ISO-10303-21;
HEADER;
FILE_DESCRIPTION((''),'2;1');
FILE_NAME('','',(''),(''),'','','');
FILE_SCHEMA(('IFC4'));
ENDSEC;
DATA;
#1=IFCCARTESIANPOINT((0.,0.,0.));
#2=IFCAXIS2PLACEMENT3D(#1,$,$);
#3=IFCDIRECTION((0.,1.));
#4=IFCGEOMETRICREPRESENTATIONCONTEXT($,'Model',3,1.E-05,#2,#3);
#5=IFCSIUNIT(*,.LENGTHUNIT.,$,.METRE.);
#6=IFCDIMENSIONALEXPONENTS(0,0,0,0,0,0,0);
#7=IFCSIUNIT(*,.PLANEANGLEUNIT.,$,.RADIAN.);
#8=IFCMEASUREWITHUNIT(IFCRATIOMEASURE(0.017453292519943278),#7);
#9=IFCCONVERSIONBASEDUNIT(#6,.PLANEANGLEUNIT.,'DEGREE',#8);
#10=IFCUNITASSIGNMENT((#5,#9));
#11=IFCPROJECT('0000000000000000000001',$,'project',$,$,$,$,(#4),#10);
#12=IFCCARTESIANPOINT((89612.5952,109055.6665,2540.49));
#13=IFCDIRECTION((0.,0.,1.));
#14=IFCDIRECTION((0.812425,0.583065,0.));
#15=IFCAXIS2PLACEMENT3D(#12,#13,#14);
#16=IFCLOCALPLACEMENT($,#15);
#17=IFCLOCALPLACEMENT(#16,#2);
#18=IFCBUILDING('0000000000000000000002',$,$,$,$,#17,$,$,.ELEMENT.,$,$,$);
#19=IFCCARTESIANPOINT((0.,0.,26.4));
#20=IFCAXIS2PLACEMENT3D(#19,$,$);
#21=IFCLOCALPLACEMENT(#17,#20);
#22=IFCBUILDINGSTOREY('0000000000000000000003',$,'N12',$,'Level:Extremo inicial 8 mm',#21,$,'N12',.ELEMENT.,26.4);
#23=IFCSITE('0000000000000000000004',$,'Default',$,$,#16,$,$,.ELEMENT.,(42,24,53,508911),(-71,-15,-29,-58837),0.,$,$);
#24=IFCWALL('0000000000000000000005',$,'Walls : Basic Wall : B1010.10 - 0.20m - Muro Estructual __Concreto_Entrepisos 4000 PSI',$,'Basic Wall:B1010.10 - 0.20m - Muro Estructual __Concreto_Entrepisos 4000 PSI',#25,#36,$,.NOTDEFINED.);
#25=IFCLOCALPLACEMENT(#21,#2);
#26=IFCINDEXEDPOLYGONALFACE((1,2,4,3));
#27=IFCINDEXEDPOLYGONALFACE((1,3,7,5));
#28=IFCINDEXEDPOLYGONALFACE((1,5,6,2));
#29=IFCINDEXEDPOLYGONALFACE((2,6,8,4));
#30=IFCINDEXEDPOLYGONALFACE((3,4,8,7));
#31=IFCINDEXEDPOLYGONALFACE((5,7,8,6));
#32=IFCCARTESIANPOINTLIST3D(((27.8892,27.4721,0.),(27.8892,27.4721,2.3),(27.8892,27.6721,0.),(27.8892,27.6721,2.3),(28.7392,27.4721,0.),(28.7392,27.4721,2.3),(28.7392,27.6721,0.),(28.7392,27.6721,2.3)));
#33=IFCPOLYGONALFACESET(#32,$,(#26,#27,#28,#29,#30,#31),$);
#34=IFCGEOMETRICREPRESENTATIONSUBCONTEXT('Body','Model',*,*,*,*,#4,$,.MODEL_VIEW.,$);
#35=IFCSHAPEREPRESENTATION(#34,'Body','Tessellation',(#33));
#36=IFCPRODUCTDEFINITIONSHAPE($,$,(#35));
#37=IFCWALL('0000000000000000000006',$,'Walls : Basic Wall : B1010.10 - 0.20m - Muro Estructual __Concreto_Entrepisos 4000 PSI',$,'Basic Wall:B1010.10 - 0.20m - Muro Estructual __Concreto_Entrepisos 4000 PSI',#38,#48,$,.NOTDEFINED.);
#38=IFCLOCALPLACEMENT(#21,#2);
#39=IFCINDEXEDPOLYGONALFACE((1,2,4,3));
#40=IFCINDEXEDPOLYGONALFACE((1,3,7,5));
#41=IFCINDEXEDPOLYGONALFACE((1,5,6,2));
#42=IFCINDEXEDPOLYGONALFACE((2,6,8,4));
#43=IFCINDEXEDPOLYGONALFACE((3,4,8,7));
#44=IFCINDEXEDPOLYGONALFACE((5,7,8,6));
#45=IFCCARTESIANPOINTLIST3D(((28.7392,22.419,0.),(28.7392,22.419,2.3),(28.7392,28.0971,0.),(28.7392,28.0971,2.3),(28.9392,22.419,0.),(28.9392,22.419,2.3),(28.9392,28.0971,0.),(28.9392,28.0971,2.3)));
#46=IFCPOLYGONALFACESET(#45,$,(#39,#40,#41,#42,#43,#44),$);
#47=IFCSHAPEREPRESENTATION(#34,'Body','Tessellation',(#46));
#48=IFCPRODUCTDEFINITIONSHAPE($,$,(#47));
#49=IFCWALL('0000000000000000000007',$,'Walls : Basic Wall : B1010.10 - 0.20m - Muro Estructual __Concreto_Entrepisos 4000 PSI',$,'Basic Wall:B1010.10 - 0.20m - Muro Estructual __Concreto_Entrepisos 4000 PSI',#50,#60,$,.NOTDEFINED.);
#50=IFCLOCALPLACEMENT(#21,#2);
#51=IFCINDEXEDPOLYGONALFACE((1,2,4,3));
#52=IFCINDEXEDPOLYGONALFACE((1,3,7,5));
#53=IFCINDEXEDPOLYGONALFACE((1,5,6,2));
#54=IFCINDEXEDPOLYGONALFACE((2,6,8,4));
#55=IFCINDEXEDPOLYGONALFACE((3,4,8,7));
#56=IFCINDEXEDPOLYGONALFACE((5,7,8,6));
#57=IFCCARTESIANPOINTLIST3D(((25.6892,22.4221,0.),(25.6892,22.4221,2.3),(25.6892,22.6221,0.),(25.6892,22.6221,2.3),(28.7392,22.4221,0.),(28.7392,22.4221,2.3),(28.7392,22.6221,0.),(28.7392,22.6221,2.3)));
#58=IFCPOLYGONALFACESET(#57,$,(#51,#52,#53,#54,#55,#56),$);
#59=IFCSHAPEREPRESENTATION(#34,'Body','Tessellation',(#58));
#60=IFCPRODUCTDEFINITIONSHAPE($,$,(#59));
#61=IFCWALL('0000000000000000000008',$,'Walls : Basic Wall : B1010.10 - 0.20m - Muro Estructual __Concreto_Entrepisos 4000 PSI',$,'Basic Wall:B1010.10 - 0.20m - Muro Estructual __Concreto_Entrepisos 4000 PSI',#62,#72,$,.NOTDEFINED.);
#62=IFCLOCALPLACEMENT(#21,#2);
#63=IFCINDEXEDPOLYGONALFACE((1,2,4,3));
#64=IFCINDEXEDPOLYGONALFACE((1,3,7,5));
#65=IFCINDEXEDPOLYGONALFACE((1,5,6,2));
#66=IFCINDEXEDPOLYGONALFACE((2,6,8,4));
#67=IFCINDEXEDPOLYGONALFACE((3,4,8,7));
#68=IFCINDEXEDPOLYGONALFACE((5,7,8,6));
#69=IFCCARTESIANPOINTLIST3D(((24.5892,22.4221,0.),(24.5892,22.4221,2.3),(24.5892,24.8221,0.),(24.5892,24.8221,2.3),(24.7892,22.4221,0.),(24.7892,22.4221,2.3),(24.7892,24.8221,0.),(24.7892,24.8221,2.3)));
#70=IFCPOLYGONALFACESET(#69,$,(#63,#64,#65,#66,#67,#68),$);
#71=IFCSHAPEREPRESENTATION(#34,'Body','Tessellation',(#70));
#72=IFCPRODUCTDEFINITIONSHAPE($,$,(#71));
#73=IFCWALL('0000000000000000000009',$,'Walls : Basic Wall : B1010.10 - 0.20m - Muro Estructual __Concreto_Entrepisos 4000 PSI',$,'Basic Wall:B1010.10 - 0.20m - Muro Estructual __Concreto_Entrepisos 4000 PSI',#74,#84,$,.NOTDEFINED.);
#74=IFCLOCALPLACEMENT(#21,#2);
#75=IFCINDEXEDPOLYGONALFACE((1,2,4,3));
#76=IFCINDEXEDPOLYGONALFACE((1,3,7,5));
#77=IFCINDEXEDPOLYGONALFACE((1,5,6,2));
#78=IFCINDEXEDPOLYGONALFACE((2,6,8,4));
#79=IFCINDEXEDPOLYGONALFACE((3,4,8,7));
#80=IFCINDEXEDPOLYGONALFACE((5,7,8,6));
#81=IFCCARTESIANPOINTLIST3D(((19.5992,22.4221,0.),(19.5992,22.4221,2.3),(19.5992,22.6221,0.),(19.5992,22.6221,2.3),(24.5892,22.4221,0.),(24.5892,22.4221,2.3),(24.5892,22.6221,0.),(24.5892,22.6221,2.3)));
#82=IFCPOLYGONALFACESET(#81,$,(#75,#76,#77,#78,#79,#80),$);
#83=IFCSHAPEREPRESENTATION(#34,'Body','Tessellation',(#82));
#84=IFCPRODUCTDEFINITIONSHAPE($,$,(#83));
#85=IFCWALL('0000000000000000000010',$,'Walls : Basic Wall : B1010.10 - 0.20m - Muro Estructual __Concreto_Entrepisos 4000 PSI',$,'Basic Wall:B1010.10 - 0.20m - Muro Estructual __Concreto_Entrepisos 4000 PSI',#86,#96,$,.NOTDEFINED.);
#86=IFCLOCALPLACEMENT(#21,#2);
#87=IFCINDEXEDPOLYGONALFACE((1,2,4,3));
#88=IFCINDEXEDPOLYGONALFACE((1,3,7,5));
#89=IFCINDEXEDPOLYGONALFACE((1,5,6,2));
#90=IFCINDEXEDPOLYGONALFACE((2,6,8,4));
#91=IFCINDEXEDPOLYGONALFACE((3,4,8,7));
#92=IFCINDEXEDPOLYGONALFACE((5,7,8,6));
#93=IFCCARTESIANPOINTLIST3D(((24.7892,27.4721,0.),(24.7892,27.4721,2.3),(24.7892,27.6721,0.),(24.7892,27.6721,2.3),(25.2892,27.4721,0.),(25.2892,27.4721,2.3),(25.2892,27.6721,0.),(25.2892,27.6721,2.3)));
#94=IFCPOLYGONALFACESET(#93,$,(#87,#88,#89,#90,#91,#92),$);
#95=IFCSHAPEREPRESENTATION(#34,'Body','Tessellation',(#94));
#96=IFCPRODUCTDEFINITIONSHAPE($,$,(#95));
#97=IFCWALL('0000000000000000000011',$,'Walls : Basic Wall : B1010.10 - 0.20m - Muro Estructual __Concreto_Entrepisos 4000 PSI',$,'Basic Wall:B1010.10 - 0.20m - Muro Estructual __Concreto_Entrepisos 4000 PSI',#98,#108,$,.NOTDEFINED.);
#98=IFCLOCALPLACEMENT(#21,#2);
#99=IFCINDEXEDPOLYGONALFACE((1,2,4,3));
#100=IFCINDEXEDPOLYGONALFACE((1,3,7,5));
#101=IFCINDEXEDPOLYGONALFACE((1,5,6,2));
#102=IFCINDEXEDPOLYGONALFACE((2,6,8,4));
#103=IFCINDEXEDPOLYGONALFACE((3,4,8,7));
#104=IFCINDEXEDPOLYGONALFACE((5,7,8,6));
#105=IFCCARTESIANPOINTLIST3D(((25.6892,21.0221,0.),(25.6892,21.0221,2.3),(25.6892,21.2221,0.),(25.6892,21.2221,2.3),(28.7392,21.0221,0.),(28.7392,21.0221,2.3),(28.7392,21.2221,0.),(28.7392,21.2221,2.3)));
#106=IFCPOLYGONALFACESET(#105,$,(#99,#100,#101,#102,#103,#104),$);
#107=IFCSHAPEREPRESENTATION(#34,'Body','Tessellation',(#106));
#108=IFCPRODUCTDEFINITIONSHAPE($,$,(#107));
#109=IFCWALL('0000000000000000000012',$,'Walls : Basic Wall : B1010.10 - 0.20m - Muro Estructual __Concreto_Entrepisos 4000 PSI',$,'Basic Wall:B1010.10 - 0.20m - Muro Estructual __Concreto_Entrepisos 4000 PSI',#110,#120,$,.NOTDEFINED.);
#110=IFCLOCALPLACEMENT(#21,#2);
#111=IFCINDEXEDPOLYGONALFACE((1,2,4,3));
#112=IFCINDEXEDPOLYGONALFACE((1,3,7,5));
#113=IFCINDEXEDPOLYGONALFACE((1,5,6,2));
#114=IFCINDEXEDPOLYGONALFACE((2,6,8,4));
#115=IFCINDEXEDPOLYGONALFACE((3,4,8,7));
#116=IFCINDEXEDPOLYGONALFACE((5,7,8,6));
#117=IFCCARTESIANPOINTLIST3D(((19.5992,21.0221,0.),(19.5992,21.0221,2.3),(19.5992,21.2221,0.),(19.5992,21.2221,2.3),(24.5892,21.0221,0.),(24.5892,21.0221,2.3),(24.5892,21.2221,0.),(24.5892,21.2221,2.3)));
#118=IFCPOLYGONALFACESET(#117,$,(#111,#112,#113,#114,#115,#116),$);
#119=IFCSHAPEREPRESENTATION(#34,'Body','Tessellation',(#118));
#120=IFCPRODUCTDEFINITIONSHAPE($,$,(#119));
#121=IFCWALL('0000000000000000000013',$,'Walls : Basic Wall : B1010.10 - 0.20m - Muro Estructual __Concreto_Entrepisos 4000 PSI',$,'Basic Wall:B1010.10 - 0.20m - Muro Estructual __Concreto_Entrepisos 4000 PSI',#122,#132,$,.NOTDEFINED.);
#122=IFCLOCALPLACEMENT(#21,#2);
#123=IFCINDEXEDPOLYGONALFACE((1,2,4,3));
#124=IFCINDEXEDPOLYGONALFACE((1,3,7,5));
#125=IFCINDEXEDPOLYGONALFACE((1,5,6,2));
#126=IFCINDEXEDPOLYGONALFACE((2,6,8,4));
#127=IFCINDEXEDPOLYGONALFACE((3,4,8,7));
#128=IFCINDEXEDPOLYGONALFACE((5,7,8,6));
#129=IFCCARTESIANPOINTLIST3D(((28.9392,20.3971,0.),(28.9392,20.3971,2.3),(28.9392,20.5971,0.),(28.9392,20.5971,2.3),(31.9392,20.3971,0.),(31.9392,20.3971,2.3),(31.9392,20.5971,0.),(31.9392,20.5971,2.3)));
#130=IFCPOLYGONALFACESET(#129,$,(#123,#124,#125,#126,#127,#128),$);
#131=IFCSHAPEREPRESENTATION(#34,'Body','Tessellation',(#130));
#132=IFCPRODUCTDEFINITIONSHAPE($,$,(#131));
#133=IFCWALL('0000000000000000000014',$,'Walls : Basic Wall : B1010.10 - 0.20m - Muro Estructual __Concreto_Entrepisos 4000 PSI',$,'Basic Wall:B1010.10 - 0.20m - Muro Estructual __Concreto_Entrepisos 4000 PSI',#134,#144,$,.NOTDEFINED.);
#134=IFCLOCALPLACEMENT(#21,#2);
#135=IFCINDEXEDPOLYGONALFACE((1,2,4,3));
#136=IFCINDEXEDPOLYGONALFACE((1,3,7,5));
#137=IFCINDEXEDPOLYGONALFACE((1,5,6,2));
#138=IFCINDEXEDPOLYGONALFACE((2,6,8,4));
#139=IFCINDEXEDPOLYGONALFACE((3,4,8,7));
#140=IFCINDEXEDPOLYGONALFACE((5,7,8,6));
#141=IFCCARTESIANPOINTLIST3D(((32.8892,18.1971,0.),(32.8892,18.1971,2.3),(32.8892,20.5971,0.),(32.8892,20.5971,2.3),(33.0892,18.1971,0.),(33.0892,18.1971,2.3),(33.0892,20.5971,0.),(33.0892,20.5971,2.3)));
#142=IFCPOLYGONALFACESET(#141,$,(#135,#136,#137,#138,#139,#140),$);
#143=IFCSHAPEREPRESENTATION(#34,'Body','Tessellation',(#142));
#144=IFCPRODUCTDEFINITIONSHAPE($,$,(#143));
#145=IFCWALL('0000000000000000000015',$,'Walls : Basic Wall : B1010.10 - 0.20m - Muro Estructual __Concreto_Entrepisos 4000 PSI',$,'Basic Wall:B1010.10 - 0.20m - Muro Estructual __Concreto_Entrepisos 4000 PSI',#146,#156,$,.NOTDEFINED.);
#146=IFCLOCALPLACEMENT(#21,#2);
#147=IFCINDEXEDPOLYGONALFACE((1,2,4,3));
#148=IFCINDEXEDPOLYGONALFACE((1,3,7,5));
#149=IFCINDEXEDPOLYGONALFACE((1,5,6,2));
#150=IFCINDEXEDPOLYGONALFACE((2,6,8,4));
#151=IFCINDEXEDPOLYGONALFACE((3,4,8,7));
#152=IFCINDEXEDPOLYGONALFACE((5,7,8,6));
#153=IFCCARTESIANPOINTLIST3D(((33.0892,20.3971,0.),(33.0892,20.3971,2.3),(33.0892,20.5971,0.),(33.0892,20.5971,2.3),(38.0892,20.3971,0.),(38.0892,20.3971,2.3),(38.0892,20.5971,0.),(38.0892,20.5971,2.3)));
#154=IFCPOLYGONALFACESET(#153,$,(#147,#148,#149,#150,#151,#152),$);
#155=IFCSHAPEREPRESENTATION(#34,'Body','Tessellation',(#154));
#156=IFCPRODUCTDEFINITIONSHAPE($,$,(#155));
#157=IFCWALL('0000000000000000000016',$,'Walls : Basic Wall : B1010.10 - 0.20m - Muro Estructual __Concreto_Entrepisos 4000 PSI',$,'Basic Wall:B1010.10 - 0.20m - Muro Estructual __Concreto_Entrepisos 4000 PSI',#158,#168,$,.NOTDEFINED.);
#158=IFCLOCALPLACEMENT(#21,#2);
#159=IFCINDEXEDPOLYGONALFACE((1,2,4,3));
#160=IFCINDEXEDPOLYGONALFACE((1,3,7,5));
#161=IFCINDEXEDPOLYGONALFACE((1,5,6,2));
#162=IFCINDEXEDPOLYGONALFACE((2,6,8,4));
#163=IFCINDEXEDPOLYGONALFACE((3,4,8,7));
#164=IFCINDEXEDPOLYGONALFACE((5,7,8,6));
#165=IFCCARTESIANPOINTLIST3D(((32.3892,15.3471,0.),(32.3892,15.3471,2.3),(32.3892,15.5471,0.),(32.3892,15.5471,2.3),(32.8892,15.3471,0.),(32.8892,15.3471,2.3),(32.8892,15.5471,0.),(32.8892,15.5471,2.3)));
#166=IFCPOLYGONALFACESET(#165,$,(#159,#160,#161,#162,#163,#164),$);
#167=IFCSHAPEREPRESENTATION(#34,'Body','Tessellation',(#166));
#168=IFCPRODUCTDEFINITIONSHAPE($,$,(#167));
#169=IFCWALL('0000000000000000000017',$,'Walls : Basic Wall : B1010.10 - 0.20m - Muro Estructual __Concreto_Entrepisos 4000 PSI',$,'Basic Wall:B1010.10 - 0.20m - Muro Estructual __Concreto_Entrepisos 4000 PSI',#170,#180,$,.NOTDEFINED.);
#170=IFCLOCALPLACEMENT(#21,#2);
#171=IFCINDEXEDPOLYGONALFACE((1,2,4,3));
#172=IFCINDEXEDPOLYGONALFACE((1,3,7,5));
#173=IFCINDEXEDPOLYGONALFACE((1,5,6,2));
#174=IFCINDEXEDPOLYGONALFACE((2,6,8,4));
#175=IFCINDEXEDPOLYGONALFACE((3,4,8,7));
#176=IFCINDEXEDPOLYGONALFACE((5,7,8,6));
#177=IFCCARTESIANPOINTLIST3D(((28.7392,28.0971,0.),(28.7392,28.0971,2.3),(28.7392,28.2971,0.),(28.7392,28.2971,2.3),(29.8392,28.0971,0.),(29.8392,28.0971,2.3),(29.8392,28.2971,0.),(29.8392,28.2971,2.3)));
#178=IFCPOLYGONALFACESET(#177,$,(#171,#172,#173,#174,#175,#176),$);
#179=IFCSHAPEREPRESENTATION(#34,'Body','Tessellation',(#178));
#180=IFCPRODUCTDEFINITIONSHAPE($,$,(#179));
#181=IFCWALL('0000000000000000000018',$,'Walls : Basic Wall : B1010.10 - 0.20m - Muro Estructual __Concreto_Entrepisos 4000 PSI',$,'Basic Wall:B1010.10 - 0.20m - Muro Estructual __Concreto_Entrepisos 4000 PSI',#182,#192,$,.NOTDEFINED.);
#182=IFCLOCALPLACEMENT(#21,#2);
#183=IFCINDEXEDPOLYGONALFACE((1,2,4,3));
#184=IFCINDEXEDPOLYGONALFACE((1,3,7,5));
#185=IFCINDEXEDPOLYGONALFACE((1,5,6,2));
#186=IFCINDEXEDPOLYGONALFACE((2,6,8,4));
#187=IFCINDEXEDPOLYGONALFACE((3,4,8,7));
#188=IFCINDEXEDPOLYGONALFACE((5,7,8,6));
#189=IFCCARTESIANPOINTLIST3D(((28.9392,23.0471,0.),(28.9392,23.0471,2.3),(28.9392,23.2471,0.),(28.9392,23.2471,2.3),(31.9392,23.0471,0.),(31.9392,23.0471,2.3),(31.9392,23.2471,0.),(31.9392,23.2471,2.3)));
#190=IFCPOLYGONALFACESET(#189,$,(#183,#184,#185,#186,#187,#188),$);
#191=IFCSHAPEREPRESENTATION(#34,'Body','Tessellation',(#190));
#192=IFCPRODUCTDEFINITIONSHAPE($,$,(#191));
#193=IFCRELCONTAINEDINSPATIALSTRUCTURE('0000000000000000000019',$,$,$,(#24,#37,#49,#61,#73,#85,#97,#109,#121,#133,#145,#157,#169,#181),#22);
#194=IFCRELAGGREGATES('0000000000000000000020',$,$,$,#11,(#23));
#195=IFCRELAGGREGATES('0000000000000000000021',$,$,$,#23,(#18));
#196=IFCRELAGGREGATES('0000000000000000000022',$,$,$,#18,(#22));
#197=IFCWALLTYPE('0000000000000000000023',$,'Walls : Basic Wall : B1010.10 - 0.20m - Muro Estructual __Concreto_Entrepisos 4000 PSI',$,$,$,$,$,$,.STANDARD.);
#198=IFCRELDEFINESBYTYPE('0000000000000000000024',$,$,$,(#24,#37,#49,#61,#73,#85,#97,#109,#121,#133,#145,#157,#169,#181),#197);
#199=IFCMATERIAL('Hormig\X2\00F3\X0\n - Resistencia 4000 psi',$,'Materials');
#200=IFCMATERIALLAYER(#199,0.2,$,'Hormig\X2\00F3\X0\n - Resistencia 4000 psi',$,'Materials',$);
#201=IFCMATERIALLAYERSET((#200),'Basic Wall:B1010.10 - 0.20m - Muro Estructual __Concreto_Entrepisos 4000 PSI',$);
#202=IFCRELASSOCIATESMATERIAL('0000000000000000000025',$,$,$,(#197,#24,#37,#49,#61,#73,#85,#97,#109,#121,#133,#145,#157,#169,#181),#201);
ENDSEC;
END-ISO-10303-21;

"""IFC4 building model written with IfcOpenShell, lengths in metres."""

from ifc_helpers import new_model, entity, si_unit, converted_unit, direction, frame, frame_2d, origin, place, context, subcontext, project, spatial, rectangle, extrude, material, layer, layer_set, layer_usage, type_object, element, save


model = new_model("IFC4")

# Units and contexts
model_context = context("Model", 3, precision=1e-05, world=origin(), true_north=direction((0.0, 1.0)))
body_context = subcontext(model_context, "Body", "Model", "MODEL_VIEW")
ifc_project = project(units=[si_unit("LENGTHUNIT", "METRE"), converted_unit("PLANEANGLEUNIT", "DEGREE", entity("IfcRatioMeasure", 0.017453292519943278), si_unit("PLANEANGLEUNIT", "RADIAN"), dimensions=[0, 0, 0, 0, 0, 0, 0])], contexts=[model_context])

# Site, building, storey
site_placement = place(None, frame((89612.5952, 109055.6665, 2540.49), z_axis=(0.0, 0.0, 1.0), x_axis=(0.812425, 0.583065, 0.0)))
site = spatial("IfcSite", under=ifc_project, at=site_placement, Name="Default", CompositionType="ELEMENT", RefLatitude=(42, 24, 53, 508911), RefLongitude=(-71, -15, -29, -58837), RefElevation=0.0)
building_placement = place(site_placement, origin())
building = spatial("IfcBuilding", under=site, at=building_placement, CompositionType="ELEMENT")
storey_placement = place(building_placement, frame((0.0, 0.0, 26.4)))
storey = spatial("IfcBuildingStorey", under=building, at=storey_placement, Name="N12", ObjectType="Level:Extremo inicial 8 mm", LongName="N12", CompositionType="ELEMENT", Elevation=26.4)

# Walls
ifc_material = material(Name="Hormigón - Resistencia 4000 psi", Category="Materials")
ifc_layer_1 = layer(ifc_material, 0.2, Name="Hormigón - Resistencia 4000 psi", Category="Materials")
ifc_layer_set_1 = layer_set([ifc_layer_1], Name="Basic Wall:B1010.10 - 0.20m - Muro Estructual __Concreto_Entrepisos 4000 PSI")
ifc_layer_usage_1 = layer_usage(ifc_layer_set_1, "AXIS2", "NEGATIVE", 0.1)
wall_type_1 = type_object("IfcWallType", Name="Walls : Basic Wall : B1010.10 - 0.20m - Muro Estructual __Concreto_Entrepisos 4000 PSI", PredefinedType="STANDARD", material=ifc_layer_set_1)
wall_1_placement = place(storey_placement, frame((27.8892, 27.5721, 0.0)))
element("IfcWall", 1, at=wall_1_placement, inside=storey, type_object=wall_type_1, material=ifc_layer_usage_1, Name="Walls : Basic Wall : B1010.10 - 0.20m - Muro Estructual __Concreto_Entrepisos 4000 PSI", ObjectType="Basic Wall:B1010.10 - 0.20m - Muro Estructual __Concreto_Entrepisos 4000 PSI", PredefinedType="NOTDEFINED", context=body_context, shape_type="SweptSolid", body=[
    extrude(rectangle(XDim=0.85, YDim=0.2, at=frame_2d((0.425, 0.0), x_axis=(-1.0, 0.0))), origin(), (0.0, 0.0, 1.0), 2.3),
])
ifc_layer_usage_2 = layer_usage(ifc_layer_set_1, "AXIS2", "NEGATIVE", 0.1)
wall_2_placement = place(storey_placement, frame((28.8392, 28.0971, 0.0), z_axis=(0.0, 0.0, 1.0), x_axis=(0.0, -1.0, 0.0)))
element("IfcWall", 2, at=wall_2_placement, inside=storey, type_object=wall_type_1, material=ifc_layer_usage_2, Name="Walls : Basic Wall : B1010.10 - 0.20m - Muro Estructual __Concreto_Entrepisos 4000 PSI", ObjectType="Basic Wall:B1010.10 - 0.20m - Muro Estructual __Concreto_Entrepisos 4000 PSI", PredefinedType="NOTDEFINED", context=body_context, shape_type="SweptSolid", body=[
    extrude(rectangle(XDim=5.6781, YDim=0.2, at=frame_2d((2.839, 0.0), x_axis=(-1.0, 0.0))), origin(), (0.0, 0.0, 1.0), 2.3),
])
ifc_layer_usage_3 = layer_usage(ifc_layer_set_1, "AXIS2", "NEGATIVE", 0.1)
wall_3_placement = place(storey_placement, frame((28.7392, 22.5221, 0.0), z_axis=(0.0, 0.0, 1.0), x_axis=(-1.0, 0.0, 0.0)))
element("IfcWall", 3, at=wall_3_placement, inside=storey, type_object=wall_type_1, material=ifc_layer_usage_3, Name="Walls : Basic Wall : B1010.10 - 0.20m - Muro Estructual __Concreto_Entrepisos 4000 PSI", ObjectType="Basic Wall:B1010.10 - 0.20m - Muro Estructual __Concreto_Entrepisos 4000 PSI", PredefinedType="NOTDEFINED", context=body_context, shape_type="SweptSolid", body=[
    extrude(rectangle(XDim=3.05, YDim=0.2, at=frame_2d((1.525, 0.0), x_axis=(-1.0, 0.0))), origin(), (0.0, 0.0, 1.0), 2.3),
])
ifc_layer_usage_4 = layer_usage(ifc_layer_set_1, "AXIS2", "NEGATIVE", 0.1)
wall_4_placement = place(storey_placement, frame((24.6892, 24.8221, 0.0), z_axis=(0.0, 0.0, 1.0), x_axis=(0.0, -1.0, 0.0)))
element("IfcWall", 4, at=wall_4_placement, inside=storey, type_object=wall_type_1, material=ifc_layer_usage_4, Name="Walls : Basic Wall : B1010.10 - 0.20m - Muro Estructual __Concreto_Entrepisos 4000 PSI", ObjectType="Basic Wall:B1010.10 - 0.20m - Muro Estructual __Concreto_Entrepisos 4000 PSI", PredefinedType="NOTDEFINED", context=body_context, shape_type="SweptSolid", body=[
    extrude(rectangle(XDim=2.4, YDim=0.2, at=frame_2d((1.2, 0.0), x_axis=(-1.0, 0.0))), origin(), (0.0, 0.0, 1.0), 2.3),
])
ifc_layer_usage_5 = layer_usage(ifc_layer_set_1, "AXIS2", "NEGATIVE", 0.1)
wall_5_placement = place(storey_placement, frame((24.5892, 22.5221, 0.0), z_axis=(0.0, 0.0, 1.0), x_axis=(-1.0, 0.0, 0.0)))
element("IfcWall", 5, at=wall_5_placement, inside=storey, type_object=wall_type_1, material=ifc_layer_usage_5, Name="Walls : Basic Wall : B1010.10 - 0.20m - Muro Estructual __Concreto_Entrepisos 4000 PSI", ObjectType="Basic Wall:B1010.10 - 0.20m - Muro Estructual __Concreto_Entrepisos 4000 PSI", PredefinedType="NOTDEFINED", context=body_context, shape_type="SweptSolid", body=[
    extrude(rectangle(XDim=4.99, YDim=0.2, at=frame_2d((2.495, 0.0), x_axis=(-1.0, 0.0))), origin(), (0.0, 0.0, 1.0), 2.3),
])
ifc_layer_usage_6 = layer_usage(ifc_layer_set_1, "AXIS2", "NEGATIVE", 0.1)
wall_6_placement = place(storey_placement, frame((25.2892, 27.5721, 0.0), z_axis=(0.0, 0.0, 1.0), x_axis=(-1.0, 0.0, 0.0)))
element("IfcWall", 6, at=wall_6_placement, inside=storey, type_object=wall_type_1, material=ifc_layer_usage_6, Name="Walls : Basic Wall : B1010.10 - 0.20m - Muro Estructual __Concreto_Entrepisos 4000 PSI", ObjectType="Basic Wall:B1010.10 - 0.20m - Muro Estructual __Concreto_Entrepisos 4000 PSI", PredefinedType="NOTDEFINED", context=body_context, shape_type="SweptSolid", body=[
    extrude(rectangle(XDim=0.5, YDim=0.2, at=frame_2d((0.25, 0.0), x_axis=(-1.0, 0.0))), origin(), (0.0, 0.0, 1.0), 2.3),
])
ifc_layer_usage_7 = layer_usage(ifc_layer_set_1, "AXIS2", "POSITIVE", -0.1)
wall_7_placement = place(storey_placement, frame((28.7392, 21.1221, 0.0), z_axis=(0.0, 0.0, 1.0), x_axis=(-1.0, 0.0, 0.0)))
element("IfcWall", 7, at=wall_7_placement, inside=storey, type_object=wall_type_1, material=ifc_layer_usage_7, Name="Walls : Basic Wall : B1010.10 - 0.20m - Muro Estructual __Concreto_Entrepisos 4000 PSI", ObjectType="Basic Wall:B1010.10 - 0.20m - Muro Estructual __Concreto_Entrepisos 4000 PSI", PredefinedType="NOTDEFINED", context=body_context, shape_type="SweptSolid", body=[
    extrude(rectangle(XDim=3.05, YDim=0.2, at=frame_2d((1.525, 0.0), x_axis=(-1.0, 0.0))), origin(), (0.0, 0.0, 1.0), 2.3),
])
ifc_layer_usage_8 = layer_usage(ifc_layer_set_1, "AXIS2", "POSITIVE", -0.1)
wall_8_placement = place(storey_placement, frame((24.5892, 21.1221, 0.0), z_axis=(0.0, 0.0, 1.0), x_axis=(-1.0, 0.0, 0.0)))
element("IfcWall", 8, at=wall_8_placement, inside=storey, type_object=wall_type_1, material=ifc_layer_usage_8, Name="Walls : Basic Wall : B1010.10 - 0.20m - Muro Estructual __Concreto_Entrepisos 4000 PSI", ObjectType="Basic Wall:B1010.10 - 0.20m - Muro Estructual __Concreto_Entrepisos 4000 PSI", PredefinedType="NOTDEFINED", context=body_context, shape_type="SweptSolid", body=[
    extrude(rectangle(XDim=4.99, YDim=0.2, at=frame_2d((2.495, 0.0), x_axis=(-1.0, 0.0))), origin(), (0.0, 0.0, 1.0), 2.3),
])
ifc_layer_usage_9 = layer_usage(ifc_layer_set_1, "AXIS2", "NEGATIVE", 0.1)
wall_9_placement = place(storey_placement, frame((28.9392, 20.4971, 0.0)))
element("IfcWall", 9, at=wall_9_placement, inside=storey, type_object=wall_type_1, material=ifc_layer_usage_9, Name="Walls : Basic Wall : B1010.10 - 0.20m - Muro Estructual __Concreto_Entrepisos 4000 PSI", ObjectType="Basic Wall:B1010.10 - 0.20m - Muro Estructual __Concreto_Entrepisos 4000 PSI", PredefinedType="NOTDEFINED", context=body_context, shape_type="SweptSolid", body=[
    extrude(rectangle(XDim=3.0, YDim=0.2, at=frame_2d((1.5, 0.0), x_axis=(-1.0, 0.0))), origin(), (0.0, 0.0, 1.0), 2.3),
])
ifc_layer_usage_10 = layer_usage(ifc_layer_set_1, "AXIS2", "NEGATIVE", 0.1)
wall_10_placement = place(storey_placement, frame((32.9892, 18.1971, 0.0), z_axis=(0.0, 0.0, 1.0), x_axis=(0.0, 1.0, 0.0)))
element("IfcWall", 10, at=wall_10_placement, inside=storey, type_object=wall_type_1, material=ifc_layer_usage_10, Name="Walls : Basic Wall : B1010.10 - 0.20m - Muro Estructual __Concreto_Entrepisos 4000 PSI", ObjectType="Basic Wall:B1010.10 - 0.20m - Muro Estructual __Concreto_Entrepisos 4000 PSI", PredefinedType="NOTDEFINED", context=body_context, shape_type="SweptSolid", body=[
    extrude(rectangle(XDim=2.4, YDim=0.2, at=frame_2d((1.2, 0.0), x_axis=(-1.0, 0.0))), origin(), (0.0, 0.0, 1.0), 2.3),
])
ifc_layer_usage_11 = layer_usage(ifc_layer_set_1, "AXIS2", "NEGATIVE", 0.1)
wall_11_placement = place(storey_placement, frame((33.0892, 20.4971, 0.0)))
element("IfcWall", 11, at=wall_11_placement, inside=storey, type_object=wall_type_1, material=ifc_layer_usage_11, Name="Walls : Basic Wall : B1010.10 - 0.20m - Muro Estructual __Concreto_Entrepisos 4000 PSI", ObjectType="Basic Wall:B1010.10 - 0.20m - Muro Estructual __Concreto_Entrepisos 4000 PSI", PredefinedType="NOTDEFINED", context=body_context, shape_type="SweptSolid", body=[
    extrude(rectangle(XDim=5.0, YDim=0.2, at=frame_2d((2.5, 0.0), x_axis=(-1.0, 0.0))), origin(), (0.0, 0.0, 1.0), 2.3),
])
ifc_layer_usage_12 = layer_usage(ifc_layer_set_1, "AXIS2", "NEGATIVE", 0.1)
wall_12_placement = place(storey_placement, frame((32.3892, 15.4471, 0.0)))
element("IfcWall", 12, at=wall_12_placement, inside=storey, type_object=wall_type_1, material=ifc_layer_usage_12, Name="Walls : Basic Wall : B1010.10 - 0.20m - Muro Estructual __Concreto_Entrepisos 4000 PSI", ObjectType="Basic Wall:B1010.10 - 0.20m - Muro Estructual __Concreto_Entrepisos 4000 PSI", PredefinedType="NOTDEFINED", context=body_context, shape_type="SweptSolid", body=[
    extrude(rectangle(XDim=0.5, YDim=0.2, at=frame_2d((0.25, 0.0), x_axis=(-1.0, 0.0))), origin(), (0.0, 0.0, 1.0), 2.3),
])
ifc_layer_usage_13 = layer_usage(ifc_layer_set_1, "AXIS2", "POSITIVE", -0.1)
wall_13_placement = place(storey_placement, frame((29.8392, 28.1971, 0.0), z_axis=(0.0, 0.0, 1.0), x_axis=(-1.0, 0.0, 0.0)))
element("IfcWall", 13, at=wall_13_placement, inside=storey, type_object=wall_type_1, material=ifc_layer_usage_13, Name="Walls : Basic Wall : B1010.10 - 0.20m - Muro Estructual __Concreto_Entrepisos 4000 PSI", ObjectType="Basic Wall:B1010.10 - 0.20m - Muro Estructual __Concreto_Entrepisos 4000 PSI", PredefinedType="NOTDEFINED", context=body_context, shape_type="SweptSolid", body=[
    extrude(rectangle(XDim=1.1, YDim=0.2, at=frame_2d((0.55, 0.0), x_axis=(-1.0, 0.0))), origin(), (0.0, 0.0, 1.0), 2.3),
])
ifc_layer_usage_14 = layer_usage(ifc_layer_set_1, "AXIS2", "POSITIVE", -0.1)
wall_14_placement = place(storey_placement, frame((28.9392, 23.1471, 0.0)))
element("IfcWall", 14, at=wall_14_placement, inside=storey, type_object=wall_type_1, material=ifc_layer_usage_14, Name="Walls : Basic Wall : B1010.10 - 0.20m - Muro Estructual __Concreto_Entrepisos 4000 PSI", ObjectType="Basic Wall:B1010.10 - 0.20m - Muro Estructual __Concreto_Entrepisos 4000 PSI", PredefinedType="NOTDEFINED", context=body_context, shape_type="SweptSolid", body=[
    extrude(rectangle(XDim=3.0, YDim=0.2, at=frame_2d((1.5, 0.0), x_axis=(-1.0, 0.0))), origin(), (0.0, 0.0, 1.0), 2.3),
])

save(model, "model.ifc")
